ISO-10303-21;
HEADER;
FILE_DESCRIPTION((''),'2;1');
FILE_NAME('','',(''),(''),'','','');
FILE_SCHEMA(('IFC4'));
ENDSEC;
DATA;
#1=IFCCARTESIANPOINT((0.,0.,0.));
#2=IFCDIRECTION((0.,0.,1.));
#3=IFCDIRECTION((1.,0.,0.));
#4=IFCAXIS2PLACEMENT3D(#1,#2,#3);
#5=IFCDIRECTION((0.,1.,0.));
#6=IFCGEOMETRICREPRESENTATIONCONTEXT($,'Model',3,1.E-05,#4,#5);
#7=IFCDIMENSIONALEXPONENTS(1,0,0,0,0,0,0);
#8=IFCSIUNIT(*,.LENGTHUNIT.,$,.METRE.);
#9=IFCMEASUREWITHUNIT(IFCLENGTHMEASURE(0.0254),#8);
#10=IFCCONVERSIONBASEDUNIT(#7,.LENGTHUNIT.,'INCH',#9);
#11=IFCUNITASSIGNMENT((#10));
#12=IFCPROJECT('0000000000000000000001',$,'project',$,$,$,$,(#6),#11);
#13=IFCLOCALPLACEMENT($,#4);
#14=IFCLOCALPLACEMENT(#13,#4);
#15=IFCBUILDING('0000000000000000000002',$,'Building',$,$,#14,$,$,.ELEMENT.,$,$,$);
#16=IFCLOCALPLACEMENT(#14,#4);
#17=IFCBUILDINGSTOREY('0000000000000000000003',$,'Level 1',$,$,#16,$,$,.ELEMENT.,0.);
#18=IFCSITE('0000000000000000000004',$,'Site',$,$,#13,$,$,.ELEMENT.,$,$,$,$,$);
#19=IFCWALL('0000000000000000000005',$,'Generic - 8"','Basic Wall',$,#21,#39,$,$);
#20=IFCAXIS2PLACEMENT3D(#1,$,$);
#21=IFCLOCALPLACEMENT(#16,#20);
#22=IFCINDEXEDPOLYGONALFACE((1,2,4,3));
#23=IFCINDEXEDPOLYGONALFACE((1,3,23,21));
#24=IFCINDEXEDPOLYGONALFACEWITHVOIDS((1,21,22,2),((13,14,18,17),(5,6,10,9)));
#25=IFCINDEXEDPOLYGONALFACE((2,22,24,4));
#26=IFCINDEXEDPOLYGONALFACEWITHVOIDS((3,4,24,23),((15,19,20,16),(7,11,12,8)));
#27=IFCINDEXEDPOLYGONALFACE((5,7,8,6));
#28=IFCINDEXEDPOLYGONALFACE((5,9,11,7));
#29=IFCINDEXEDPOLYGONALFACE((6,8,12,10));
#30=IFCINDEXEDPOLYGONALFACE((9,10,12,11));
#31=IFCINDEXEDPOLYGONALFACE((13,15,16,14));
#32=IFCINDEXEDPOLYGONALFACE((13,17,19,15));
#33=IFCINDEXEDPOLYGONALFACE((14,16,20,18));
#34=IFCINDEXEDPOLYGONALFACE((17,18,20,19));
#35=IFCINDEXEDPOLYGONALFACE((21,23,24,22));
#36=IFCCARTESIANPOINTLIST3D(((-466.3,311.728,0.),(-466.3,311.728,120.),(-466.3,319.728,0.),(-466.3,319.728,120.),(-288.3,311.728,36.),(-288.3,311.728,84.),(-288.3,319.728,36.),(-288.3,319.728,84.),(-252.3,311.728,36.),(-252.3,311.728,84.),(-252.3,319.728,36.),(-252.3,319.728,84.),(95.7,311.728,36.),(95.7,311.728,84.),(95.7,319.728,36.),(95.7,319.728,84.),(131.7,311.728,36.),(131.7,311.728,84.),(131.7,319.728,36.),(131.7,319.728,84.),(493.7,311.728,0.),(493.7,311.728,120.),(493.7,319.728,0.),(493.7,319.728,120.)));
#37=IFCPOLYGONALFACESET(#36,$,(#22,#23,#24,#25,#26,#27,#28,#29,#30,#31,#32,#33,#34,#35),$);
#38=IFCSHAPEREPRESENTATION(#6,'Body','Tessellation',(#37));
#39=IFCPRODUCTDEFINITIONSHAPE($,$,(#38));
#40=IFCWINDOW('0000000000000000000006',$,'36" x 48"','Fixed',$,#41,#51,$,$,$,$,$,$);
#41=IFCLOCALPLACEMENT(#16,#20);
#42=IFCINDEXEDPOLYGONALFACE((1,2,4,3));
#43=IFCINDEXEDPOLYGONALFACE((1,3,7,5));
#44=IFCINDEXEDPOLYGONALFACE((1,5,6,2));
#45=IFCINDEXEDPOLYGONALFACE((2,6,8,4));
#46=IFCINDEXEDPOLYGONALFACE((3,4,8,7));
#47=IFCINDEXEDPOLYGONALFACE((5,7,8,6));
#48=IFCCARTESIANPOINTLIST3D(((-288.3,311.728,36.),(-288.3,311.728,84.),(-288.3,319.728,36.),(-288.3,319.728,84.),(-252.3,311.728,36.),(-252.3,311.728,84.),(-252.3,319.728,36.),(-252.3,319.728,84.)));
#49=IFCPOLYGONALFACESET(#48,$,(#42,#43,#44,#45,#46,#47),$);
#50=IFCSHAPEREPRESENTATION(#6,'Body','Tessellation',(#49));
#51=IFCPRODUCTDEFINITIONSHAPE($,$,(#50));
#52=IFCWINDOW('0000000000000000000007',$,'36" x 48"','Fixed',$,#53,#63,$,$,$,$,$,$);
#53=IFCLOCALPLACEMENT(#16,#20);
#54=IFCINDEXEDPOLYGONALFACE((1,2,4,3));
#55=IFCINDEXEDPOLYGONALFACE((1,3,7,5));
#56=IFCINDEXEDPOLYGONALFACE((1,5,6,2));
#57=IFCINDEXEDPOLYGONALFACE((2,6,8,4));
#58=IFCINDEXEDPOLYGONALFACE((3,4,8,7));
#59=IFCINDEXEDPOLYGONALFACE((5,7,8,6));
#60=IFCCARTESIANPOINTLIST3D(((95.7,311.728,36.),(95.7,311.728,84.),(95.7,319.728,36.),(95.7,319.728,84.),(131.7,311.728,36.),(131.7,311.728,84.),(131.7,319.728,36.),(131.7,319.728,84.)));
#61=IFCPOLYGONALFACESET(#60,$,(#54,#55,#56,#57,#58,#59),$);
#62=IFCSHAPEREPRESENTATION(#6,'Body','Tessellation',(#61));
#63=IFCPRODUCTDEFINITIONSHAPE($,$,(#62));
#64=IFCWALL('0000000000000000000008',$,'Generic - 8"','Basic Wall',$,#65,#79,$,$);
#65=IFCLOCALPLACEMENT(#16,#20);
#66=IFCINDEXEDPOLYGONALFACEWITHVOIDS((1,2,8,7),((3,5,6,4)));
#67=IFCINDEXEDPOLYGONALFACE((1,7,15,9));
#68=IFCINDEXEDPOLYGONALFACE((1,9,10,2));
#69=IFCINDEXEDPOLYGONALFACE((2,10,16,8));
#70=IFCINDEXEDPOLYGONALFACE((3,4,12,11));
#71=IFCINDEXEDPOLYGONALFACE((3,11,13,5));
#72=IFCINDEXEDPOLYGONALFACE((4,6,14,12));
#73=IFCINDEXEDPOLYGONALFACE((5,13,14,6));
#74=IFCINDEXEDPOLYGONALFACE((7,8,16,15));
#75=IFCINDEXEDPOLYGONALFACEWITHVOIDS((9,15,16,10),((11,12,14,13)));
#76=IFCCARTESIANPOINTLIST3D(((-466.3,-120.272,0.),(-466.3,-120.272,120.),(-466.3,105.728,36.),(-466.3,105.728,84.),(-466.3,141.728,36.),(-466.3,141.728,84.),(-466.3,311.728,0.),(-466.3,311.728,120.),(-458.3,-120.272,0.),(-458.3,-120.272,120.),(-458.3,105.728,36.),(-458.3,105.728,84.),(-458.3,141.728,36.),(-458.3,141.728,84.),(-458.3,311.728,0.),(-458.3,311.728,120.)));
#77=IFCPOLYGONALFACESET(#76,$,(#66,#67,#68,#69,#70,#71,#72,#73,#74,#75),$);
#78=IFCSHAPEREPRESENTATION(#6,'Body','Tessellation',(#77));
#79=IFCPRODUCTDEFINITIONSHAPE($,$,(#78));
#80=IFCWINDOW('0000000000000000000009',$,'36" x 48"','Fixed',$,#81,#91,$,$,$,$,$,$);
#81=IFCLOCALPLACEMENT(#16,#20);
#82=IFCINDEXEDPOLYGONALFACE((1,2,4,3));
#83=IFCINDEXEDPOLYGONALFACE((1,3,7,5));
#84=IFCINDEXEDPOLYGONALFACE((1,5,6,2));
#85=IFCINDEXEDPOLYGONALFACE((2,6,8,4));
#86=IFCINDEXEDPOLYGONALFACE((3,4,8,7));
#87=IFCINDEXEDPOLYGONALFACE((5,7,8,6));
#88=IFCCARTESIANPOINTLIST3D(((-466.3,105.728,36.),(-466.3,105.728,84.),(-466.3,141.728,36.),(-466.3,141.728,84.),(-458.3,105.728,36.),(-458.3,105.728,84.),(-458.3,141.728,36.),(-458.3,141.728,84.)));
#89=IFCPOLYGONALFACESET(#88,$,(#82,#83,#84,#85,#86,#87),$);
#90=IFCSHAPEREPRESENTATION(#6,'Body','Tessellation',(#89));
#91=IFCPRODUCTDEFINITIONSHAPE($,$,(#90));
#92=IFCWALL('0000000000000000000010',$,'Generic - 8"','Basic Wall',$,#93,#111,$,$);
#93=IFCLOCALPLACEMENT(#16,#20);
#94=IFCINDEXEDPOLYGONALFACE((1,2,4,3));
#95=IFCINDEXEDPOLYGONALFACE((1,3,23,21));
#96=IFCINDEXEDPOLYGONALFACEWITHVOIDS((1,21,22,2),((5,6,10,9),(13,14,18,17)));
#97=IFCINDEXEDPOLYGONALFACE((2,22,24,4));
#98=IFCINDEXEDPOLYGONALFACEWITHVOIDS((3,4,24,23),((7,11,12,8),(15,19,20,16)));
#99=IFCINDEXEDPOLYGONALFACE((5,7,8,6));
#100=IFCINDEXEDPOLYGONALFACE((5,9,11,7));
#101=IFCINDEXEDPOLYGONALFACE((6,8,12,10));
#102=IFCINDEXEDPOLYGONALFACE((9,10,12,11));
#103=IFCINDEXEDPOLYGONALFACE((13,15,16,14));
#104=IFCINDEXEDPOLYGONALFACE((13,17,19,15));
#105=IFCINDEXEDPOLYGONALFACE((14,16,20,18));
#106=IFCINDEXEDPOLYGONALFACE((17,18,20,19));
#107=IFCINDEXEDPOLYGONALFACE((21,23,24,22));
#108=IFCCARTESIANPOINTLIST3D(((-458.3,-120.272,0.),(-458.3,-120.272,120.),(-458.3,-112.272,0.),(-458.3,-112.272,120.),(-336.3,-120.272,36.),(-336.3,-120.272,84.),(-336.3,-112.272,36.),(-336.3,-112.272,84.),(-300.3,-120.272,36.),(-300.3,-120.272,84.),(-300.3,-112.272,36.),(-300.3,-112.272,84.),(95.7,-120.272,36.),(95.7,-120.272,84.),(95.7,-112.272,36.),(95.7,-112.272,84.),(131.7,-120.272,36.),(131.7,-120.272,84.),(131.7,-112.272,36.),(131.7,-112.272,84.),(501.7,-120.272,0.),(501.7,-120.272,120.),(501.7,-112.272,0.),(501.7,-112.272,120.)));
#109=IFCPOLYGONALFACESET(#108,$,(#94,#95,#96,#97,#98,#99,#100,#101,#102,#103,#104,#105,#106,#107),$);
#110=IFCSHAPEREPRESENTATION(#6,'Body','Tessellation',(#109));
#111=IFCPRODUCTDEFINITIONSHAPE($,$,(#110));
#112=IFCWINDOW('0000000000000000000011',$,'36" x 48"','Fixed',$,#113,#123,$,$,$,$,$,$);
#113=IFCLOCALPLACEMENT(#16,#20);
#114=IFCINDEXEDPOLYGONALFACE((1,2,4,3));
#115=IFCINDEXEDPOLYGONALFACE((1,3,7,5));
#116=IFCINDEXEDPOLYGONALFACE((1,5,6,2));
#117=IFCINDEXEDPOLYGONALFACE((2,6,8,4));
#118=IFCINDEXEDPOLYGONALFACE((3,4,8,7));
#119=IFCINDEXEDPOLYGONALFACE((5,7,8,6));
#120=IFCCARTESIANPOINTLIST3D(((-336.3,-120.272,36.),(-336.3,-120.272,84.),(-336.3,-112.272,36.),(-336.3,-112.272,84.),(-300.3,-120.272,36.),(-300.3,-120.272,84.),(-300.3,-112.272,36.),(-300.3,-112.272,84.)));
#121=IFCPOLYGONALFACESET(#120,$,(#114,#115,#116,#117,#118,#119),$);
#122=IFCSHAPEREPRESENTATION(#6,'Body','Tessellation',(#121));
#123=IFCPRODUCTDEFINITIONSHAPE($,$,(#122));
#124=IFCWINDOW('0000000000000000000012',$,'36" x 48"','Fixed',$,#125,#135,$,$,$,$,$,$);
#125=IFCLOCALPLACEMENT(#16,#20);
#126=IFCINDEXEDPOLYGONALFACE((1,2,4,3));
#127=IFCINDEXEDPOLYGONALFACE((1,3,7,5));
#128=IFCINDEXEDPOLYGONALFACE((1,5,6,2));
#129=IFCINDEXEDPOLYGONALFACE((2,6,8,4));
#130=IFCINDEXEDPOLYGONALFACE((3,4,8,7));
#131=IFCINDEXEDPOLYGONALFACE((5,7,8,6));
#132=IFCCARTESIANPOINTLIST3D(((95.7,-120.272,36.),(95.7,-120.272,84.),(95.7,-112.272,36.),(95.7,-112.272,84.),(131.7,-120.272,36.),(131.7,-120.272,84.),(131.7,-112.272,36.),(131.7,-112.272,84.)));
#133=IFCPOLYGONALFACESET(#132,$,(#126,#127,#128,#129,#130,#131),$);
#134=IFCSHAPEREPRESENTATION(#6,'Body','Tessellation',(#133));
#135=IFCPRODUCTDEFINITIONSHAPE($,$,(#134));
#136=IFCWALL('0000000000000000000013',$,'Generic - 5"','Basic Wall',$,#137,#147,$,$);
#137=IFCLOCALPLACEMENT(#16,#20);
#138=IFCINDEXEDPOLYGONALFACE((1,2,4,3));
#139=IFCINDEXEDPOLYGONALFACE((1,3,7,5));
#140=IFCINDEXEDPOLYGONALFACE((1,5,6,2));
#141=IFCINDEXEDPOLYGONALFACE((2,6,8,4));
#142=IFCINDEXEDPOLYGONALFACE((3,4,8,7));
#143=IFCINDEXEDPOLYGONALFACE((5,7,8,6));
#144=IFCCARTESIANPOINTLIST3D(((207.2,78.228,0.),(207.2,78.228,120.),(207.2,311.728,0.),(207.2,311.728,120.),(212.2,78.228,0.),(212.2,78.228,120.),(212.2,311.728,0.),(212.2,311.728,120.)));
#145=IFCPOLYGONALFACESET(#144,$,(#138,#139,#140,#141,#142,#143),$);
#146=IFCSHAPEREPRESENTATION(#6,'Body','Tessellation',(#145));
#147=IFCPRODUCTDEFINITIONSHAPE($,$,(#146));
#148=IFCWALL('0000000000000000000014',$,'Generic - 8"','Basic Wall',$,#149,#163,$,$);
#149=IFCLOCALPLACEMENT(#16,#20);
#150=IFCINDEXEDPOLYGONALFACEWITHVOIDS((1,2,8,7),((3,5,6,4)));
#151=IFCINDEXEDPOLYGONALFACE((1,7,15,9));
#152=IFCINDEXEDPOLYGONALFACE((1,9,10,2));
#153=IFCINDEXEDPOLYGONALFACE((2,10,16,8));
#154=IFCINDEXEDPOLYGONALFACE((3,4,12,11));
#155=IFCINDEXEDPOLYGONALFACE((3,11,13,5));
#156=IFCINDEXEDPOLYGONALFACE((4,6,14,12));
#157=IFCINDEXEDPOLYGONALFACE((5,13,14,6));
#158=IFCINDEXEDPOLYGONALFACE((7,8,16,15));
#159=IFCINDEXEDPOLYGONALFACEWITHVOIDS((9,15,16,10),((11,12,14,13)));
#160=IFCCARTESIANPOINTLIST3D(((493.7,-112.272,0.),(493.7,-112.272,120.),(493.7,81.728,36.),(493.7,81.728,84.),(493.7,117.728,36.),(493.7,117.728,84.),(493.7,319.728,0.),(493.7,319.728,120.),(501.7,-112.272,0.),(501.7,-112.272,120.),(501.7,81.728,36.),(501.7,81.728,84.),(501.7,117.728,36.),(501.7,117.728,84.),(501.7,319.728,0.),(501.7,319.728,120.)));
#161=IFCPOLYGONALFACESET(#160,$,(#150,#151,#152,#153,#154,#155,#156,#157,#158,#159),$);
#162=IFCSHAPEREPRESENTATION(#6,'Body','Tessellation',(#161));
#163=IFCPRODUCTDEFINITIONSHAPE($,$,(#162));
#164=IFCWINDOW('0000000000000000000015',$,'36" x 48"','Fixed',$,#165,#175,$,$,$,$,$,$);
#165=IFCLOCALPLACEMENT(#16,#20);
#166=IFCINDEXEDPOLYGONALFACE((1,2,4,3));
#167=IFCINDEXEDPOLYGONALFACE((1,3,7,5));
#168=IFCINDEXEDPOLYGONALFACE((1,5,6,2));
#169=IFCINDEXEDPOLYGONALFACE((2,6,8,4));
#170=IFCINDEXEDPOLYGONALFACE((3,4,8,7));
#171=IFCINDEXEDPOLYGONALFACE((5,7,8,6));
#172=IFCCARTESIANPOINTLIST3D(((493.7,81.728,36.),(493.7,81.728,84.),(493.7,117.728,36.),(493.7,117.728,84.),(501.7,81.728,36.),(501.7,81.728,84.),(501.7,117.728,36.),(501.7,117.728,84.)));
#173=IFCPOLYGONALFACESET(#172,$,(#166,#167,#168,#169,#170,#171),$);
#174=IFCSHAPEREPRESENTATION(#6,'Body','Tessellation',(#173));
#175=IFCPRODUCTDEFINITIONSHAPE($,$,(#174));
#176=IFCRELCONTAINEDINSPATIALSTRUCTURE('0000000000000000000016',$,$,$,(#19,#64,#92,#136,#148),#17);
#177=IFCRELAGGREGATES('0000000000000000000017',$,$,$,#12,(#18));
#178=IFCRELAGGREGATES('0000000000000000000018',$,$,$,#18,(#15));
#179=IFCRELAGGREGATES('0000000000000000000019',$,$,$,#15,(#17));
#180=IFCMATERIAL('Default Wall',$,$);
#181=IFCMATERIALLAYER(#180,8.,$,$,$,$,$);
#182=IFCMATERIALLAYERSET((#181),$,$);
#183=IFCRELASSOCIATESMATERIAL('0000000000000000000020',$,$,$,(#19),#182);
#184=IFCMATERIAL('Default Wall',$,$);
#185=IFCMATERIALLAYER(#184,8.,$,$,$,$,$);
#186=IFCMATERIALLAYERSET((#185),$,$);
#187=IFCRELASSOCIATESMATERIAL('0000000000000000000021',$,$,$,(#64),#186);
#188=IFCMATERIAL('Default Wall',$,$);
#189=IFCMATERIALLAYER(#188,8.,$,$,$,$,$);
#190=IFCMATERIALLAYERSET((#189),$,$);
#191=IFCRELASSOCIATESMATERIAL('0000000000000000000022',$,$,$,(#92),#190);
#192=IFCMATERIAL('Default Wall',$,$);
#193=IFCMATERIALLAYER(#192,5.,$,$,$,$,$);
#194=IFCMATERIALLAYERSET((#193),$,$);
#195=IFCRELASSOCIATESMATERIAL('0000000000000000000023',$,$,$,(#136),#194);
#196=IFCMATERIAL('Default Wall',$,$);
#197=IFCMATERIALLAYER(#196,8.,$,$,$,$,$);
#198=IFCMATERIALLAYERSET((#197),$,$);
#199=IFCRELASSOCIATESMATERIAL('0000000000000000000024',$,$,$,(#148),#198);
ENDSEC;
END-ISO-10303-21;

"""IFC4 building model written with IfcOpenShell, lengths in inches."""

from ifc_helpers import new_model, entity, si_unit, converted_unit, direction, origin_with_axes, place, context, project, spatial, polyline, outline, extrude, material, layer, layer_set, layer_usage, element, fill, save


model = new_model("IFC4")

# Units and contexts
model_context = context("Model", 3, precision=1e-05, world=origin_with_axes(), true_north=direction((0.0, 1.0, 0.0)))
ifc_project = project(units=[converted_unit("LENGTHUNIT", "INCH", entity("IfcLengthMeasure", 0.0254), si_unit("LENGTHUNIT", "METRE"), dimensions=[1, 0, 0, 0, 0, 0, 0])], contexts=[model_context])

# Site, building, storey
site_placement = place(None, origin_with_axes())
site = spatial("IfcSite", under=ifc_project, at=site_placement, Name="Site", CompositionType="ELEMENT")
building_placement = place(site_placement, origin_with_axes())
building = spatial("IfcBuilding", under=site, at=building_placement, Name="Building", CompositionType="ELEMENT")
storey_placement = place(building_placement, origin_with_axes())
storey = spatial("IfcBuildingStorey", under=building, at=storey_placement, Name="Level 1", CompositionType="ELEMENT", Elevation=0.0)

# Wall, openings, windows
ifc_material_1 = material(Name="Default Wall")
ifc_layer_1 = layer(ifc_material_1, 8.0)
ifc_layer_set_1 = layer_set([ifc_layer_1])
ifc_layer_usage_1 = layer_usage(ifc_layer_set_1, "AXIS2", "NEGATIVE", 4.0)
wall_1_placement = place(storey_placement, origin_with_axes())
wall_1 = element("IfcWall", 1, at=wall_1_placement, inside=storey, material=ifc_layer_usage_1, Name="Generic - 8\"", Description="Basic Wall", context=model_context, shape_type="SweptSolid", body=[
    extrude(outline(polyline([(-466.3, 311.728, 0.0), (-466.3, 319.728, 0.0), (493.7, 319.728, 0.0), (493.7, 311.728, 0.0), (-466.3, 311.728, 0.0)])), origin_with_axes(), (0.0, 0.0, 1.0), 120.0),
])
opening_1_placement = place(wall_1_placement, origin_with_axes())
opening_1 = element("IfcOpeningElement", 2, at=opening_1_placement, cuts=wall_1, PredefinedType="OPENING", context=model_context, shape_type="SweptSolid", body=[
    extrude(outline(polyline([(-288.3, 311.728, 36.0), (-252.3, 311.728, 36.0), (-252.3, 319.728, 36.0), (-288.3, 319.728, 36.0), (-288.3, 311.728, 36.0)])), origin_with_axes(), (0.0, 0.0, 1.0), 48.0),
])
opening_2_placement = place(wall_1_placement, origin_with_axes())
opening_2 = element("IfcOpeningElement", 3, at=opening_2_placement, cuts=wall_1, PredefinedType="OPENING", context=model_context, shape_type="SweptSolid", body=[
    extrude(outline(polyline([(95.7, 311.728, 36.0), (131.7, 311.728, 36.0), (131.7, 319.728, 36.0), (95.7, 319.728, 36.0), (95.7, 311.728, 36.0)])), origin_with_axes(), (0.0, 0.0, 1.0), 48.0),
])
window_1_placement = place(opening_1_placement, origin_with_axes())
window_1 = element("IfcWindow", 4, at=window_1_placement, Name="36\" x 48\"", Description="Fixed", context=model_context, shape_type="SweptSolid", body=[
    extrude(outline(polyline([(-288.3, 311.728, 36.0), (-252.3, 311.728, 36.0), (-252.3, 319.728, 36.0), (-288.3, 319.728, 36.0), (-288.3, 311.728, 36.0)])), origin_with_axes(), (0.0, 0.0, 1.0), 48.0),
])
fill(opening_1, window_1)
window_2_placement = place(opening_2_placement, origin_with_axes())
window_2 = element("IfcWindow", 5, at=window_2_placement, Name="36\" x 48\"", Description="Fixed", context=model_context, shape_type="SweptSolid", body=[
    extrude(outline(polyline([(95.7, 311.728, 36.0), (131.7, 311.728, 36.0), (131.7, 319.728, 36.0), (95.7, 319.728, 36.0), (95.7, 311.728, 36.0)])), origin_with_axes(), (0.0, 0.0, 1.0), 48.0),
])
fill(opening_2, window_2)

# Wall, opening, window
ifc_material_2 = material(Name="Default Wall")
ifc_layer_2 = layer(ifc_material_2, 8.0)
ifc_layer_set_2 = layer_set([ifc_layer_2])
ifc_layer_usage_2 = layer_usage(ifc_layer_set_2, "AXIS2", "NEGATIVE", 4.0)
wall_2_placement = place(storey_placement, origin_with_axes())
wall_2 = element("IfcWall", 6, at=wall_2_placement, inside=storey, material=ifc_layer_usage_2, Name="Generic - 8\"", Description="Basic Wall", context=model_context, shape_type="SweptSolid", body=[
    extrude(outline(polyline([(-466.3, -120.272, 0.0), (-466.3, 311.728, 0.0), (-458.3, 311.728, 0.0), (-458.3, -120.272, 0.0), (-466.3, -120.272, 0.0)])), origin_with_axes(), (0.0, 0.0, 1.0), 120.0),
])
opening_3_placement = place(wall_2_placement, origin_with_axes())
opening_3 = element("IfcOpeningElement", 7, at=opening_3_placement, cuts=wall_2, PredefinedType="OPENING", context=model_context, shape_type="SweptSolid", body=[
    extrude(outline(polyline([(-466.3, 105.728, 36.0), (-458.3, 105.728, 36.0), (-458.3, 141.728, 36.0), (-466.3, 141.728, 36.0), (-466.3, 105.728, 36.0)])), origin_with_axes(), (0.0, 0.0, 1.0), 48.0),
])
window_3_placement = place(opening_3_placement, origin_with_axes())
window_3 = element("IfcWindow", 8, at=window_3_placement, Name="36\" x 48\"", Description="Fixed", context=model_context, shape_type="SweptSolid", body=[
    extrude(outline(polyline([(-466.3, 105.728, 36.0), (-458.3, 105.728, 36.0), (-458.3, 141.728, 36.0), (-466.3, 141.728, 36.0), (-466.3, 105.728, 36.0)])), origin_with_axes(), (0.0, 0.0, 1.0), 48.0),
])
fill(opening_3, window_3)

# Wall, openings, windows
ifc_material_3 = material(Name="Default Wall")
ifc_layer_3 = layer(ifc_material_3, 8.0)
ifc_layer_set_3 = layer_set([ifc_layer_3])
ifc_layer_usage_3 = layer_usage(ifc_layer_set_3, "AXIS2", "NEGATIVE", 4.0)
wall_3_placement = place(storey_placement, origin_with_axes())
wall_3 = element("IfcWall", 9, at=wall_3_placement, inside=storey, material=ifc_layer_usage_3, Name="Generic - 8\"", Description="Basic Wall", context=model_context, shape_type="SweptSolid", body=[
    extrude(outline(polyline([(-458.3, -120.272, 0.0), (-458.3, -112.272, 0.0), (501.7, -112.272, 0.0), (501.7, -120.272, 0.0), (-458.3, -120.272, 0.0)])), origin_with_axes(), (0.0, 0.0, 1.0), 120.0),
])
opening_4_placement = place(wall_3_placement, origin_with_axes())
opening_4 = element("IfcOpeningElement", 10, at=opening_4_placement, cuts=wall_3, PredefinedType="OPENING", context=model_context, shape_type="SweptSolid", body=[
    extrude(outline(polyline([(-336.3, -120.272, 36.0), (-336.3, -112.272, 36.0), (-300.3, -112.272, 36.0), (-300.3, -120.272, 36.0), (-336.3, -120.272, 36.0)])), origin_with_axes(), (0.0, 0.0, 1.0), 48.0),
])
opening_5_placement = place(wall_3_placement, origin_with_axes())
opening_5 = element("IfcOpeningElement", 11, at=opening_5_placement, cuts=wall_3, PredefinedType="OPENING", context=model_context, shape_type="SweptSolid", body=[
    extrude(outline(polyline([(95.7, -120.272, 36.0), (131.7, -120.272, 36.0), (131.7, -112.272, 36.0), (95.7, -112.272, 36.0), (95.7, -120.272, 36.0)])), origin_with_axes(), (0.0, 0.0, 1.0), 48.0),
])
window_4_placement = place(opening_4_placement, origin_with_axes())
window_4 = element("IfcWindow", 12, at=window_4_placement, Name="36\" x 48\"", Description="Fixed", context=model_context, shape_type="SweptSolid", body=[
    extrude(outline(polyline([(-336.3, -120.272, 36.0), (-336.3, -112.272, 36.0), (-300.3, -112.272, 36.0), (-300.3, -120.272, 36.0), (-336.3, -120.272, 36.0)])), origin_with_axes(), (0.0, 0.0, 1.0), 48.0),
])
fill(opening_4, window_4)
window_5_placement = place(opening_5_placement, origin_with_axes())
window_5 = element("IfcWindow", 13, at=window_5_placement, Name="36\" x 48\"", Description="Fixed", context=model_context, shape_type="SweptSolid", body=[
    extrude(outline(polyline([(95.7, -120.272, 36.0), (131.7, -120.272, 36.0), (131.7, -112.272, 36.0), (95.7, -112.272, 36.0), (95.7, -120.272, 36.0)])), origin_with_axes(), (0.0, 0.0, 1.0), 48.0),
])
fill(opening_5, window_5)

# Wall
ifc_material_4 = material(Name="Default Wall")
ifc_layer_4 = layer(ifc_material_4, 5.0)
ifc_layer_set_4 = layer_set([ifc_layer_4])
ifc_layer_usage_4 = layer_usage(ifc_layer_set_4, "AXIS2", "NEGATIVE", 2.5)
wall_4_placement = place(storey_placement, origin_with_axes())
element("IfcWall", 14, at=wall_4_placement, inside=storey, material=ifc_layer_usage_4, Name="Generic - 5\"", Description="Basic Wall", context=model_context, shape_type="SweptSolid", body=[
    extrude(outline(polyline([(207.2, 78.228, 0.0), (207.2, 311.728, 0.0), (212.2, 311.728, 0.0), (212.2, 78.228, 0.0), (207.2, 78.228, 0.0)])), origin_with_axes(), (0.0, 0.0, 1.0), 120.0),
])

# Wall, opening, window
ifc_material_5 = material(Name="Default Wall")
ifc_layer_5 = layer(ifc_material_5, 8.0)
ifc_layer_set_5 = layer_set([ifc_layer_5])
ifc_layer_usage_5 = layer_usage(ifc_layer_set_5, "AXIS2", "NEGATIVE", 4.0)
wall_5_placement = place(storey_placement, origin_with_axes())
wall_5 = element("IfcWall", 15, at=wall_5_placement, inside=storey, material=ifc_layer_usage_5, Name="Generic - 8\"", Description="Basic Wall", context=model_context, shape_type="SweptSolid", body=[
    extrude(outline(polyline([(493.7, -112.272, 0.0), (493.7, 319.728, 0.0), (501.7, 319.728, 0.0), (501.7, -112.272, 0.0), (493.7, -112.272, 0.0)])), origin_with_axes(), (0.0, 0.0, 1.0), 120.0),
])
opening_6_placement = place(wall_5_placement, origin_with_axes())
opening_6 = element("IfcOpeningElement", 16, at=opening_6_placement, cuts=wall_5, PredefinedType="OPENING", context=model_context, shape_type="SweptSolid", body=[
    extrude(outline(polyline([(493.7, 81.728, 36.0), (493.7, 117.728, 36.0), (501.7, 117.728, 36.0), (501.7, 81.728, 36.0), (493.7, 81.728, 36.0)])), origin_with_axes(), (0.0, 0.0, 1.0), 48.0),
])
window_6_placement = place(opening_6_placement, origin_with_axes())
window_6 = element("IfcWindow", 17, at=window_6_placement, Name="36\" x 48\"", Description="Fixed", context=model_context, shape_type="SweptSolid", body=[
    extrude(outline(polyline([(493.7, 81.728, 36.0), (493.7, 117.728, 36.0), (501.7, 117.728, 36.0), (501.7, 81.728, 36.0), (493.7, 81.728, 36.0)])), origin_with_axes(), (0.0, 0.0, 1.0), 48.0),
])
fill(opening_6, window_6)

save(model, "model.ifc")
